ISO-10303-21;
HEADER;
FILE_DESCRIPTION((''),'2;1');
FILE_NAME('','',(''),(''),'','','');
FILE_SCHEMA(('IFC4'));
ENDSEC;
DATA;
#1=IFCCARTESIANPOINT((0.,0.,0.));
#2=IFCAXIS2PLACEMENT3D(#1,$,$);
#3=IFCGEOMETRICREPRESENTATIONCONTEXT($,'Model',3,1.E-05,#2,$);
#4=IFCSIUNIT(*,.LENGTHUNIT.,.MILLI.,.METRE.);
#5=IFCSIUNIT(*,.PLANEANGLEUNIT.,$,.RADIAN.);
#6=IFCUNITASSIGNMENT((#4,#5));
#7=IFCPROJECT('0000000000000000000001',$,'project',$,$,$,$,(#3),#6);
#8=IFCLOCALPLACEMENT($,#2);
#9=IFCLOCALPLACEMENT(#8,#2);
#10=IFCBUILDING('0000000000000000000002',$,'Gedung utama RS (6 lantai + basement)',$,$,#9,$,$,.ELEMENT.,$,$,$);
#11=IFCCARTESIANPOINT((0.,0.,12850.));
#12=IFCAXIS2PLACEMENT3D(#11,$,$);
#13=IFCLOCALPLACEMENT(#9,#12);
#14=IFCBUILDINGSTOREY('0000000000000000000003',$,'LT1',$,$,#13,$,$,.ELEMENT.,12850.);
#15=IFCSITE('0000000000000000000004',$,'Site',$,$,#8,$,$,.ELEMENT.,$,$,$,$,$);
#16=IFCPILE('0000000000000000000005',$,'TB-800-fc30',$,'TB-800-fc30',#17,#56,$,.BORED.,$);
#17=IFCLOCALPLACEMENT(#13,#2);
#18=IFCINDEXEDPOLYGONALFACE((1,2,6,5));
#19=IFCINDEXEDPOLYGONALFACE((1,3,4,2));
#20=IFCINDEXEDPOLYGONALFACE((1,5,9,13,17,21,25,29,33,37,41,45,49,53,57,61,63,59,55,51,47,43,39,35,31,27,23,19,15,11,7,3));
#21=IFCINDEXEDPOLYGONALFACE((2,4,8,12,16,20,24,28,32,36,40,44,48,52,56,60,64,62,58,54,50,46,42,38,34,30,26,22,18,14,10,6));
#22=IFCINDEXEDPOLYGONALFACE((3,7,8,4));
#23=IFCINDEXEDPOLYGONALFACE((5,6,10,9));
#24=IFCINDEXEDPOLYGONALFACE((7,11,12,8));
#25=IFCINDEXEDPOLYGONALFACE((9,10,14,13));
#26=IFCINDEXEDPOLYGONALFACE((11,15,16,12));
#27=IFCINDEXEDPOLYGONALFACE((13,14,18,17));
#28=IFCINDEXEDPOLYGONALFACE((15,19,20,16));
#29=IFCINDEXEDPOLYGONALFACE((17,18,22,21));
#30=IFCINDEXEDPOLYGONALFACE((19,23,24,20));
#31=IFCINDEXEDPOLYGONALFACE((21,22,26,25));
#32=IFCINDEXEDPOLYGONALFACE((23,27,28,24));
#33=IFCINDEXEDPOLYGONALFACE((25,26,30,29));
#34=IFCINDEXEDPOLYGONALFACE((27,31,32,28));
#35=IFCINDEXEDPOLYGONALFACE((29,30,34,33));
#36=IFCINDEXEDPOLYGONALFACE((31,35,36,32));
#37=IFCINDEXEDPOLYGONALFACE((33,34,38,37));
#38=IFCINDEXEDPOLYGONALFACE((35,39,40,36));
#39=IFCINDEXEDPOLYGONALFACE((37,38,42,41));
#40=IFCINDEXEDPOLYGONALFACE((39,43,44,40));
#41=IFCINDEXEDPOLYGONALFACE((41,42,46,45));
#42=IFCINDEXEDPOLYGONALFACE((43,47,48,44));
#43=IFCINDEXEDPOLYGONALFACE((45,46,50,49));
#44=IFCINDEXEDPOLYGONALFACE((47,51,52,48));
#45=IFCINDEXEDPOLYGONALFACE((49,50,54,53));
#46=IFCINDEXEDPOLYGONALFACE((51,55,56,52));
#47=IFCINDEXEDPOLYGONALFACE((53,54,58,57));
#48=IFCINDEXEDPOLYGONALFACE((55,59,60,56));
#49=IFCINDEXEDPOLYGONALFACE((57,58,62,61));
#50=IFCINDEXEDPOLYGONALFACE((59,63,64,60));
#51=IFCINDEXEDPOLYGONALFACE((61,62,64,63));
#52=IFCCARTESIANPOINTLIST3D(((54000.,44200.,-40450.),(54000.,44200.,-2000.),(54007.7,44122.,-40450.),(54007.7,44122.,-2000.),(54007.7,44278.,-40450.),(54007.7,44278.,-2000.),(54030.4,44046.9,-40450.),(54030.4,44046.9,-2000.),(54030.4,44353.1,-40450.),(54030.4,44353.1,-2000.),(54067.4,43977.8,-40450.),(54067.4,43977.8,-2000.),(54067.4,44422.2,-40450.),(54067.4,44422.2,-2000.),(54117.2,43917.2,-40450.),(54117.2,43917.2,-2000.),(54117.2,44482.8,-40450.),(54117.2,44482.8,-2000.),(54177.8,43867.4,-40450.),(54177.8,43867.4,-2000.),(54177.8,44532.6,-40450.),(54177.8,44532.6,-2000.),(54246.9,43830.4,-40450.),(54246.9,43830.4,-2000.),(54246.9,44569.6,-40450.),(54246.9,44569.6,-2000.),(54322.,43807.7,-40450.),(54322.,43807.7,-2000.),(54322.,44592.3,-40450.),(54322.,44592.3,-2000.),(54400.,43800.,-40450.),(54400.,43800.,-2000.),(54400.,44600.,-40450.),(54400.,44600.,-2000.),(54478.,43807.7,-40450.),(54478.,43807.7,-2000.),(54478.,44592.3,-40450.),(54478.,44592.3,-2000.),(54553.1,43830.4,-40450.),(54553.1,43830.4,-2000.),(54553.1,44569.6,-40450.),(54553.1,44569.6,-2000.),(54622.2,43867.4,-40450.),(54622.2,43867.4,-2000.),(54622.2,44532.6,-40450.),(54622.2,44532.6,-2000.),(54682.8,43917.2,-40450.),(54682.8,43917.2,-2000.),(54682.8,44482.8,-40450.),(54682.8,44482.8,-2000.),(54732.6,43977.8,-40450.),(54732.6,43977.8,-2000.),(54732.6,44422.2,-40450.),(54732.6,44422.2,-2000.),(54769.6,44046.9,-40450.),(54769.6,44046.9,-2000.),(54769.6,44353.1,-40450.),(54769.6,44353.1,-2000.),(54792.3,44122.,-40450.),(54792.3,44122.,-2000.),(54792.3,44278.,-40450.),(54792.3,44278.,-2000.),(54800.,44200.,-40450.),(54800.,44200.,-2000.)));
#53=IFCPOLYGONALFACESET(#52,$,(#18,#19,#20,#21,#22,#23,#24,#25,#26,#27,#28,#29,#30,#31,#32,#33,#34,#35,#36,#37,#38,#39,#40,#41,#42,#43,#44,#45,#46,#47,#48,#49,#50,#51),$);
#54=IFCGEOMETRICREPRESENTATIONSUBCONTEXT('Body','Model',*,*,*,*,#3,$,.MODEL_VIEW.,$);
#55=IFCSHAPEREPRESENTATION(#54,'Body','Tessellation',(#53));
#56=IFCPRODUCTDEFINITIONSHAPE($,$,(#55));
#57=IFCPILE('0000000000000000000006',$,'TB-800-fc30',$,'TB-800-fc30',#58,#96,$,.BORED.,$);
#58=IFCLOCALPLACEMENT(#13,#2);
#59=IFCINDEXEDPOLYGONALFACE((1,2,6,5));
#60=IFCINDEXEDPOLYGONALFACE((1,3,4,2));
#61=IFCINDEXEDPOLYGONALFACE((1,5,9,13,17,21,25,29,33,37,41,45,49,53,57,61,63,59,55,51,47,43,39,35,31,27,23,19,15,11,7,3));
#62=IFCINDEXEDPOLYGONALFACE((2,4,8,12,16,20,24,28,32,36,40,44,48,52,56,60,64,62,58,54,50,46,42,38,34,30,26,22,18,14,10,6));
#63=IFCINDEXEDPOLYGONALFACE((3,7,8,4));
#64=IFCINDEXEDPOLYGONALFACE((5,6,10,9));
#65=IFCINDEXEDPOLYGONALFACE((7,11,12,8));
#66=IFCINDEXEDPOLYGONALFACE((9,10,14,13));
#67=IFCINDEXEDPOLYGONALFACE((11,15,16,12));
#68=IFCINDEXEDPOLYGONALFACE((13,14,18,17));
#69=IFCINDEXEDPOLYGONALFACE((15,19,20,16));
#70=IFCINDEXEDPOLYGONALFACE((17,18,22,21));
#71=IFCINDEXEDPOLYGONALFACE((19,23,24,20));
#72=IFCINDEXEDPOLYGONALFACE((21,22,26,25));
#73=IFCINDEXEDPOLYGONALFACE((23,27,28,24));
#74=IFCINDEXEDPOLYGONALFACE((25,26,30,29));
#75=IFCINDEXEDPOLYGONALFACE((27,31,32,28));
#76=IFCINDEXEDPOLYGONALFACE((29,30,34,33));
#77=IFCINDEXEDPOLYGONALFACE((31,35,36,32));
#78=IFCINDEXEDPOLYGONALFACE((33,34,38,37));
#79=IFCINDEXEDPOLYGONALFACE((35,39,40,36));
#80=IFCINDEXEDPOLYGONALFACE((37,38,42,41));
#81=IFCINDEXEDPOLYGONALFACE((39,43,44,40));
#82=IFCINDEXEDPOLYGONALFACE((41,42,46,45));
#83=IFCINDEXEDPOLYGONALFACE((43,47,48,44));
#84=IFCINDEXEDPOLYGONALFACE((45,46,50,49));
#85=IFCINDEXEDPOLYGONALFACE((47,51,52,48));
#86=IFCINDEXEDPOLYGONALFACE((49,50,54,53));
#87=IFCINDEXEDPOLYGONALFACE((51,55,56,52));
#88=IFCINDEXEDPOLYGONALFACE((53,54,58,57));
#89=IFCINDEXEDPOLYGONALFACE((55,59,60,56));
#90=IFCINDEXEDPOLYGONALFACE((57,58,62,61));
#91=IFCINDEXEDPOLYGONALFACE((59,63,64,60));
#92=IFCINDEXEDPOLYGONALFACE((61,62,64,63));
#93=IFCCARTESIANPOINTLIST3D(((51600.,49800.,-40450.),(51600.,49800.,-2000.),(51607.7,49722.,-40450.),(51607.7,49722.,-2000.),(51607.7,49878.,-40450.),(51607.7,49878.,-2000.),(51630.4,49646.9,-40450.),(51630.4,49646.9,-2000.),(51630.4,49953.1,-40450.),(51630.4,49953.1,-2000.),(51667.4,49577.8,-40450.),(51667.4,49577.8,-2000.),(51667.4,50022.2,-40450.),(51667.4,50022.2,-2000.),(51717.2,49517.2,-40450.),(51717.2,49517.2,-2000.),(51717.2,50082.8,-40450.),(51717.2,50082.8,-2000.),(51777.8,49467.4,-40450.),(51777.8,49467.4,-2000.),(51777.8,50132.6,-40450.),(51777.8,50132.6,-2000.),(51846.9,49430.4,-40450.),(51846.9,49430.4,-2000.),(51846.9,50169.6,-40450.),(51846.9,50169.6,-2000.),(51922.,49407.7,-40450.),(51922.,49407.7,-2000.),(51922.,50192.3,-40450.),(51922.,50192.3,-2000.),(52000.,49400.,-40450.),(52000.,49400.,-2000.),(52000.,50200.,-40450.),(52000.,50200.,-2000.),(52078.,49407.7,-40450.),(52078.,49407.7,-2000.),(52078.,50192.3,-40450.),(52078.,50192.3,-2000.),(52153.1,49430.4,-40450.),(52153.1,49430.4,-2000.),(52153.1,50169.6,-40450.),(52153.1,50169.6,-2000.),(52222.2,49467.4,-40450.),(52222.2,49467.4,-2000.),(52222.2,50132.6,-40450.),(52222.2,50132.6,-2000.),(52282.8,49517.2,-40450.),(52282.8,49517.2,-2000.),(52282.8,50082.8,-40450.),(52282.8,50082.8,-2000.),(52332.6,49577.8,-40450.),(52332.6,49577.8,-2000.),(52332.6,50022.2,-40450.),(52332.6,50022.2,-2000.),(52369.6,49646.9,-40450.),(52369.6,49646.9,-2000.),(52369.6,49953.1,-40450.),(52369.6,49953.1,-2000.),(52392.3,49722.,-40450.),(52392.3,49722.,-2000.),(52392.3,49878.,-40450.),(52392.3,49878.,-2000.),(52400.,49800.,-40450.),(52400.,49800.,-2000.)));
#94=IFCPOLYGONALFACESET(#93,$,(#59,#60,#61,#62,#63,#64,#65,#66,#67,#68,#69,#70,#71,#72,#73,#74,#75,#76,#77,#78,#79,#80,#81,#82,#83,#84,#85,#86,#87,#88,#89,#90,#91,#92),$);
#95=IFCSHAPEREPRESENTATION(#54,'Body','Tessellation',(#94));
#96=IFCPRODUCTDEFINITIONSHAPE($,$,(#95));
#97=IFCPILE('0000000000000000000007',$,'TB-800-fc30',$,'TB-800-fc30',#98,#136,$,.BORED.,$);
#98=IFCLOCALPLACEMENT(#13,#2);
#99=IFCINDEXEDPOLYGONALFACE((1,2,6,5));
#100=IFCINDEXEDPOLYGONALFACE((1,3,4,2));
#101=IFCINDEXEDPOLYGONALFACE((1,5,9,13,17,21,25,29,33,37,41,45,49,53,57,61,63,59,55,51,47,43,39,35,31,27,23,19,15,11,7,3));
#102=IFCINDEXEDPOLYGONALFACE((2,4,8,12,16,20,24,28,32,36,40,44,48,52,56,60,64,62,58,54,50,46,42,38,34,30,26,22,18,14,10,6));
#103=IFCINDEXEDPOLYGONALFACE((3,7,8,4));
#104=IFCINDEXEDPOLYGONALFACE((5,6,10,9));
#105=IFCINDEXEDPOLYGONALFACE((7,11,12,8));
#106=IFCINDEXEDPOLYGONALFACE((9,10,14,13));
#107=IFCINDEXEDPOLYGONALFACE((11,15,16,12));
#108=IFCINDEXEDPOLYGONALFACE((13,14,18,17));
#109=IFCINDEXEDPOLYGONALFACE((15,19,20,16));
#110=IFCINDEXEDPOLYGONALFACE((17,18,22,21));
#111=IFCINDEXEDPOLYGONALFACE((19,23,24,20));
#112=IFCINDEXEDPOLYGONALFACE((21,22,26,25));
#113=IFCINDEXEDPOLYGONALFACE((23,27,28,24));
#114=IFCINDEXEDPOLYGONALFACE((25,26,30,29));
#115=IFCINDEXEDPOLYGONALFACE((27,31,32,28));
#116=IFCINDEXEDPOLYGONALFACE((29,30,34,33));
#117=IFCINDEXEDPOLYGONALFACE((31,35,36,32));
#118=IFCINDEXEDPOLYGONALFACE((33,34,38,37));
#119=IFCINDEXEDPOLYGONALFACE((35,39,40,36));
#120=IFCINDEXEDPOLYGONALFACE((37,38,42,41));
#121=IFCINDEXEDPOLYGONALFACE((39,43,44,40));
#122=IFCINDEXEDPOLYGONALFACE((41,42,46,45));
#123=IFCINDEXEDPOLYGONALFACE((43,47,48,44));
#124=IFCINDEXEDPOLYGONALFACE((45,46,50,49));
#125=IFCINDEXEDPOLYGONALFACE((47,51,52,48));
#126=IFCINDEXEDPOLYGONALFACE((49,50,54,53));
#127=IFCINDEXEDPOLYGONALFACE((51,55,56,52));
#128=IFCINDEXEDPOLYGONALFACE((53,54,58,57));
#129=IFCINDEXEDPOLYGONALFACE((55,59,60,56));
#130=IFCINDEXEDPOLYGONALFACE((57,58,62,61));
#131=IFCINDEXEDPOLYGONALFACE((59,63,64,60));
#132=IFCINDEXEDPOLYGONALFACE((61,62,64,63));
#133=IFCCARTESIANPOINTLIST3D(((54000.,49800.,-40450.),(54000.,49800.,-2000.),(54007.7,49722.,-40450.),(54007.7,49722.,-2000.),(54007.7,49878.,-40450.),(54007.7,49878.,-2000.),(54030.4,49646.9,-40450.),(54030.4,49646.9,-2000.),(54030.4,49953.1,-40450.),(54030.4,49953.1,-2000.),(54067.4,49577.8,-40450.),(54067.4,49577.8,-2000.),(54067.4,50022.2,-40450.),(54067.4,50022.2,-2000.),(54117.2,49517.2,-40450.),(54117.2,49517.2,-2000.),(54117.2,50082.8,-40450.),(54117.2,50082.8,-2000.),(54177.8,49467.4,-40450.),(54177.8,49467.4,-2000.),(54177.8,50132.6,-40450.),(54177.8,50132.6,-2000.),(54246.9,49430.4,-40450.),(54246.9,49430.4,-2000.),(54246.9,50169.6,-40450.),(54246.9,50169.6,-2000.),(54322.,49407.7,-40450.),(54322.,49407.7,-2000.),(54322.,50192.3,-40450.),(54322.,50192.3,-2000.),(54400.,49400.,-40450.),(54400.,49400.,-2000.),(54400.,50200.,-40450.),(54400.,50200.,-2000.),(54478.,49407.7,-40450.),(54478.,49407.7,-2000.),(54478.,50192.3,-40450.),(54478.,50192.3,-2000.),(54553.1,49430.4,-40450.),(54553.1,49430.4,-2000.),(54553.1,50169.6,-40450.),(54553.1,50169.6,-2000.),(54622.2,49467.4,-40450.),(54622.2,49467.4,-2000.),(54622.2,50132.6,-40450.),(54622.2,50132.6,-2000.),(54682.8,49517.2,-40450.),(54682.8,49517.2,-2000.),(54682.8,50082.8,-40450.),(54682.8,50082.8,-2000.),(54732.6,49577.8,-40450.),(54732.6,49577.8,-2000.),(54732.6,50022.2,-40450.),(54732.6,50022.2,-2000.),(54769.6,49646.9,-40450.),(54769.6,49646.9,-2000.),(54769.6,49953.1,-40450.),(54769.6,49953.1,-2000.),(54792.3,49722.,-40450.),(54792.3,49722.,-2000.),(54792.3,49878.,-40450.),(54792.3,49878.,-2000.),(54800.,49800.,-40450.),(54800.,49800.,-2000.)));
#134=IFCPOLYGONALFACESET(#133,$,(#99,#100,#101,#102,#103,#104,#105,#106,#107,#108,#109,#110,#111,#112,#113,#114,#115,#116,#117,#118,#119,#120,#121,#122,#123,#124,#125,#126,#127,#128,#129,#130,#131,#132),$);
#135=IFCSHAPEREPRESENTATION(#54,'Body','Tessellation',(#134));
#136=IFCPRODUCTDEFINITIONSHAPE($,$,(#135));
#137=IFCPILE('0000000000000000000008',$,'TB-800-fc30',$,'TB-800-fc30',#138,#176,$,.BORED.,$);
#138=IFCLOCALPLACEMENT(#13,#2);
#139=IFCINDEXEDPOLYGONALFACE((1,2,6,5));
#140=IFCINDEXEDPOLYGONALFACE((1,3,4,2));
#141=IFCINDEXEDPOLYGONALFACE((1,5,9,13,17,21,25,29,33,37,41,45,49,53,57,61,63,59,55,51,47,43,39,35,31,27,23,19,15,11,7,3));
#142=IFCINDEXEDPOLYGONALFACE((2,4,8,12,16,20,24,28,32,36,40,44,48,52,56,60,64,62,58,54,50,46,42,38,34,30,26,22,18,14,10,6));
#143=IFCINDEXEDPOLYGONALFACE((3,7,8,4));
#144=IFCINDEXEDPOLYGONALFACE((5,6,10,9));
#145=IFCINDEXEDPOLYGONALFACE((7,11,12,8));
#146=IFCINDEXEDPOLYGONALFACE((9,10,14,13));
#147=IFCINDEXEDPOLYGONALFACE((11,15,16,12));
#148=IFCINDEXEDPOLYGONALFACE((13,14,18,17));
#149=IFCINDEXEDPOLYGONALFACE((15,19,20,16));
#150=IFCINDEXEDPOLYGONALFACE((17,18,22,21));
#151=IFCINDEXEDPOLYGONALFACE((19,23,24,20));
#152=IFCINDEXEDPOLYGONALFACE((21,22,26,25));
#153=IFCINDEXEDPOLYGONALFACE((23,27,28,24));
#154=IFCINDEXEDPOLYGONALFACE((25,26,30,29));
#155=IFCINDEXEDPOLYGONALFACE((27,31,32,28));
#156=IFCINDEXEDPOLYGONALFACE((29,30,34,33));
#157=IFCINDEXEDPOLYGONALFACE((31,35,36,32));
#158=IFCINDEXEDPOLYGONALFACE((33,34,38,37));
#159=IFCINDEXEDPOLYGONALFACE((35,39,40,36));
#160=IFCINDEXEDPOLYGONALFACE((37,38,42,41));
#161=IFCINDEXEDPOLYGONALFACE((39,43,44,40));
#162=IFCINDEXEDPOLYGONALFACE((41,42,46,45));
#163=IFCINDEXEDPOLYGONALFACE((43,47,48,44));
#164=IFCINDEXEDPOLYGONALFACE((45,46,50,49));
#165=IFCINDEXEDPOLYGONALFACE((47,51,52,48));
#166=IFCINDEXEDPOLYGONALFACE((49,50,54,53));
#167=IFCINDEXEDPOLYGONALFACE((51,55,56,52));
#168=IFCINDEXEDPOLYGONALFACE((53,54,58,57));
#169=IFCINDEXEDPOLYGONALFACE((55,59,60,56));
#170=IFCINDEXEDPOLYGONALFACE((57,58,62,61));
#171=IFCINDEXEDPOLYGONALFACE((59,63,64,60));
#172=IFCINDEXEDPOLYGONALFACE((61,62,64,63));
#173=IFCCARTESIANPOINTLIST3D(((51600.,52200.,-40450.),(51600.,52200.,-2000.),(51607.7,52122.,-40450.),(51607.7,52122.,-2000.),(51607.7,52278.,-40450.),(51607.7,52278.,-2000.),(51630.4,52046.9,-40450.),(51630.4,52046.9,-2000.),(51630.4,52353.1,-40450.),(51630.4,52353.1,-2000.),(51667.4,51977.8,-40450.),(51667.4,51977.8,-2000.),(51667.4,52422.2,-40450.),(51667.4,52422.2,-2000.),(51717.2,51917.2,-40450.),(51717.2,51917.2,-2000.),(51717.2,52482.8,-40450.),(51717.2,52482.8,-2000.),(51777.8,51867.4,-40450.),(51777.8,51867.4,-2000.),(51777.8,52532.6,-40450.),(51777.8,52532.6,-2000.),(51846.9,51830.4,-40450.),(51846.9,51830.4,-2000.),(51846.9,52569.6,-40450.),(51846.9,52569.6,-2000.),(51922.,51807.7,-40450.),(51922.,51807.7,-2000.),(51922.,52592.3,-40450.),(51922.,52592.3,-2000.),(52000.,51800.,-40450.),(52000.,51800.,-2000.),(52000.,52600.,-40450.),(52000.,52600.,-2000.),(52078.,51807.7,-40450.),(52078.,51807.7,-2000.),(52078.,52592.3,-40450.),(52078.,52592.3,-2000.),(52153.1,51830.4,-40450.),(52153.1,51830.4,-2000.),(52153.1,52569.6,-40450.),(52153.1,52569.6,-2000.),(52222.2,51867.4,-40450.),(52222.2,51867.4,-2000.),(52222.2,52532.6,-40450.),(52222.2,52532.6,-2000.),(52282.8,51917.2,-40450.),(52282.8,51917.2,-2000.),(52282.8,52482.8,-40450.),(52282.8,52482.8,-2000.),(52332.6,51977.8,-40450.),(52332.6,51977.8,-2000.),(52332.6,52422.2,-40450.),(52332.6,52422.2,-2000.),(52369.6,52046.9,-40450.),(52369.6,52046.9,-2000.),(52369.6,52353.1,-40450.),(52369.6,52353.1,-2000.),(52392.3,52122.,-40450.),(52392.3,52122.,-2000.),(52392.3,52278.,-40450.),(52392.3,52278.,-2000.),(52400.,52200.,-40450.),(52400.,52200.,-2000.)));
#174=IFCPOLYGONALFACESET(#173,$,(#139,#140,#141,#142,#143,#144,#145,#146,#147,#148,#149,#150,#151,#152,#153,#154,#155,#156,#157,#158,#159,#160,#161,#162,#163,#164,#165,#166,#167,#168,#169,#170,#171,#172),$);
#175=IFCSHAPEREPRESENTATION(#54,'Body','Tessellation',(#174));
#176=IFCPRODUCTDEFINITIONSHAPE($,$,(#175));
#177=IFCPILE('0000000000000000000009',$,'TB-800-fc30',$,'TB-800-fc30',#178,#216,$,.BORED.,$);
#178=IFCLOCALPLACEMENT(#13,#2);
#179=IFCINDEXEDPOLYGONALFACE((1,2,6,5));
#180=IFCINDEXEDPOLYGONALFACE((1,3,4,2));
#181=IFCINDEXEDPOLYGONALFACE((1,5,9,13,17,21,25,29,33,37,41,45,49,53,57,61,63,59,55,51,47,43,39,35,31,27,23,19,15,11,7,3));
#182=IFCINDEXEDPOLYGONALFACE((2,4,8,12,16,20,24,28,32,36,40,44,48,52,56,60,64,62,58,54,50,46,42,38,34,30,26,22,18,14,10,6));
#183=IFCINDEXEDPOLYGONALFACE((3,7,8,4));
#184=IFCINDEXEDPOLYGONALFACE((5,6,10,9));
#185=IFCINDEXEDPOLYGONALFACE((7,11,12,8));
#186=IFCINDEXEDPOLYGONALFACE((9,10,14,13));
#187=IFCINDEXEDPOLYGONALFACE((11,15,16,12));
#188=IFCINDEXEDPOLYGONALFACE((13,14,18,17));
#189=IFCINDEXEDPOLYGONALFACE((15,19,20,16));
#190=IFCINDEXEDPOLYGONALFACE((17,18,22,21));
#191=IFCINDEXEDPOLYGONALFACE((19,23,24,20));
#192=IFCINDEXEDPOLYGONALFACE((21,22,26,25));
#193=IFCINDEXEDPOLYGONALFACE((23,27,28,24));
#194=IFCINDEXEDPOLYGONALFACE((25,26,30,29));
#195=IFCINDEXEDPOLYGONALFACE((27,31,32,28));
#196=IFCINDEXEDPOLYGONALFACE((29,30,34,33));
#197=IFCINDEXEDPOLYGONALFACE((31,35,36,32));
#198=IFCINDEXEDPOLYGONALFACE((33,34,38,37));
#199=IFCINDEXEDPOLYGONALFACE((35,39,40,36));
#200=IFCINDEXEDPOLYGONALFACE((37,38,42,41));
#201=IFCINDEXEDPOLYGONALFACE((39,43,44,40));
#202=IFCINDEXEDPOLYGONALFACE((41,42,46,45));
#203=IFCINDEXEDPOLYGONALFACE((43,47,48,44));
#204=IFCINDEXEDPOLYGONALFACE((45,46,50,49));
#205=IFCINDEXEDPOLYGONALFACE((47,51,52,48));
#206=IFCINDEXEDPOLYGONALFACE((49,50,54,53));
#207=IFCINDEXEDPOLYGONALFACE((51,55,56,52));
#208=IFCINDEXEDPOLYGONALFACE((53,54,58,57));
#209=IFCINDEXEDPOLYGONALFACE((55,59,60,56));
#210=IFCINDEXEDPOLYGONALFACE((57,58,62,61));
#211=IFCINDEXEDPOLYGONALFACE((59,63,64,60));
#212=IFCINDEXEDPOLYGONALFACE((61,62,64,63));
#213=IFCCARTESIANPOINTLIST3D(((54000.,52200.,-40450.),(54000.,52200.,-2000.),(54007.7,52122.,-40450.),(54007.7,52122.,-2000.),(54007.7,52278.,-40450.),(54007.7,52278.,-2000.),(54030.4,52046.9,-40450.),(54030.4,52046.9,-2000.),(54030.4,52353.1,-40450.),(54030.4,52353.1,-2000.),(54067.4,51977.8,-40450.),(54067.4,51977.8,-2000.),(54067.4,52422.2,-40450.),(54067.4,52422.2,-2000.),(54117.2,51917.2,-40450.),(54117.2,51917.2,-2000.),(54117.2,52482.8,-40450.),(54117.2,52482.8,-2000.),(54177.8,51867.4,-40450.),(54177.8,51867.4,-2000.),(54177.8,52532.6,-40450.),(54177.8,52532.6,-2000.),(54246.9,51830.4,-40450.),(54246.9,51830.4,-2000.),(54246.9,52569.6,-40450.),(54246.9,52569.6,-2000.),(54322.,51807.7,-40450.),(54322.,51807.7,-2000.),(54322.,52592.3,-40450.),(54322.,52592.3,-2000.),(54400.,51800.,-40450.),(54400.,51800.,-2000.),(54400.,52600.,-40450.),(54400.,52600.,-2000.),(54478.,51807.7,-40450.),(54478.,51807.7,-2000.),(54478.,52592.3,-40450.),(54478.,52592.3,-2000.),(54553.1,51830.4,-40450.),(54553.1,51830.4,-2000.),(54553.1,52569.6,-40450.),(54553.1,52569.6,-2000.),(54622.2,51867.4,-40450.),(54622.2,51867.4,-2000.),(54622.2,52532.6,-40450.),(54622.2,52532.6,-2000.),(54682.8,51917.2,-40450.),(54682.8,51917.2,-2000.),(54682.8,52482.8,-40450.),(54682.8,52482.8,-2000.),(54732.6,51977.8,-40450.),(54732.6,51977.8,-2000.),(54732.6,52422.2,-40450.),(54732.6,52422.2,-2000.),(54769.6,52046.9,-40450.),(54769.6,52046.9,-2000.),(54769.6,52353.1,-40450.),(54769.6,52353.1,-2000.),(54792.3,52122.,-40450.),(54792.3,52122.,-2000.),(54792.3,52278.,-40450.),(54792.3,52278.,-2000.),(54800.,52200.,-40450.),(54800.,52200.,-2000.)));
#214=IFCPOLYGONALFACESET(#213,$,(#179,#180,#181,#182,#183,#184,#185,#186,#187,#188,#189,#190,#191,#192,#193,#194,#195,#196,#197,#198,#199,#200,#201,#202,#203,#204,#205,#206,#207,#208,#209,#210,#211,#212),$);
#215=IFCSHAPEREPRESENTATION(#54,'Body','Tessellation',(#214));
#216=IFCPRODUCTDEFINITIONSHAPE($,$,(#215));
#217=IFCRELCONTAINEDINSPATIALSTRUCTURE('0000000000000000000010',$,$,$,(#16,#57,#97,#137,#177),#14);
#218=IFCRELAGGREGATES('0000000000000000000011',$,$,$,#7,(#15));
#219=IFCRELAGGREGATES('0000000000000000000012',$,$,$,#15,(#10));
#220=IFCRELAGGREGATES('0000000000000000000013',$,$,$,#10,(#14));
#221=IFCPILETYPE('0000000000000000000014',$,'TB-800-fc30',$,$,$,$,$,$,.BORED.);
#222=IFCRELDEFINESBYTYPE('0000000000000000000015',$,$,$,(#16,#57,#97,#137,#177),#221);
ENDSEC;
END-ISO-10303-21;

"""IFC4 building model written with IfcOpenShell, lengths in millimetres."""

from ifc_helpers import new_model, si_unit, frame, origin, origin_2d, place, context, subcontext, project, spatial, circle, extrude, material_profile, profile_set, profile_usage, type_object, element, save


model = new_model("IFC4")

# Units and contexts
model_context = context("Model", 3, precision=1e-05, world=origin())
body_context = subcontext(model_context, "Body", "Model", "MODEL_VIEW")
ifc_project = project(units=[si_unit("LENGTHUNIT", "METRE", prefix="MILLI"), si_unit("PLANEANGLEUNIT", "RADIAN")], contexts=[model_context])

# Site, building, storey
site_placement = place(None, origin())
site = spatial("IfcSite", under=ifc_project, at=site_placement, Name="Site", CompositionType="ELEMENT")
building_placement = place(site_placement, origin())
building = spatial("IfcBuilding", under=site, at=building_placement, Name="Gedung utama RS (6 lantai + basement)", CompositionType="ELEMENT")
storey_placement = place(building_placement, frame((0.0, 0.0, 12850.0)))
storey = spatial("IfcBuildingStorey", under=building, at=storey_placement, Name="LT1", CompositionType="ELEMENT", Elevation=12850.0)

# Piles
ifc_material_profile_1 = material_profile(None, circle(Radius=400.0, at=origin_2d()), Name="TB-800-fc30")
ifc_profile_set_1 = profile_set([ifc_material_profile_1], Name="TB-800-fc30")
ifc_profile_usage_1 = profile_usage(ifc_profile_set_1, cardinal=5)
pile_type = type_object("IfcPileType", Name="TB-800-fc30", PredefinedType="BORED", material=ifc_profile_set_1)
for number, where, z_axis, x_axis, name in (
    (1, (54400.0, 44200.0, -40450.0), (0.0, 0.0, 1.0), (1.0, 0.0, 0.0), "TB-800-fc30"),
    (2, (52000.0, 49800.0, -40450.0), (0.0, 0.0, 1.0), (1.0, 0.0, 0.0), "TB-800-fc30"),
    (3, (54400.0, 49800.0, -40450.0), (0.0, 0.0, 1.0), (1.0, 0.0, 0.0), "TB-800-fc30"),
    (4, (52000.0, 52200.0, -40450.0), (0.0, 0.0, 1.0), (1.0, 0.0, 0.0), "TB-800-fc30"),
    (5, (54400.0, 52200.0, -40450.0), (0.0, 0.0, 1.0), (1.0, 0.0, 0.0), "TB-800-fc30"),
):
    element("IfcPile", number, at=place(storey_placement, frame(where, z_axis=z_axis, x_axis=x_axis)), inside=storey, type_object=pile_type, material=ifc_profile_usage_1, Name=name, ObjectType="TB-800-fc30", PredefinedType="BORED", context=body_context, shape_type="SweptSolid", body=[
        extrude(circle(Radius=400.0, at=origin_2d()), origin(), (0.0, 0.0, 1.0), 38450.0),
    ])

save(model, "model.ifc")
